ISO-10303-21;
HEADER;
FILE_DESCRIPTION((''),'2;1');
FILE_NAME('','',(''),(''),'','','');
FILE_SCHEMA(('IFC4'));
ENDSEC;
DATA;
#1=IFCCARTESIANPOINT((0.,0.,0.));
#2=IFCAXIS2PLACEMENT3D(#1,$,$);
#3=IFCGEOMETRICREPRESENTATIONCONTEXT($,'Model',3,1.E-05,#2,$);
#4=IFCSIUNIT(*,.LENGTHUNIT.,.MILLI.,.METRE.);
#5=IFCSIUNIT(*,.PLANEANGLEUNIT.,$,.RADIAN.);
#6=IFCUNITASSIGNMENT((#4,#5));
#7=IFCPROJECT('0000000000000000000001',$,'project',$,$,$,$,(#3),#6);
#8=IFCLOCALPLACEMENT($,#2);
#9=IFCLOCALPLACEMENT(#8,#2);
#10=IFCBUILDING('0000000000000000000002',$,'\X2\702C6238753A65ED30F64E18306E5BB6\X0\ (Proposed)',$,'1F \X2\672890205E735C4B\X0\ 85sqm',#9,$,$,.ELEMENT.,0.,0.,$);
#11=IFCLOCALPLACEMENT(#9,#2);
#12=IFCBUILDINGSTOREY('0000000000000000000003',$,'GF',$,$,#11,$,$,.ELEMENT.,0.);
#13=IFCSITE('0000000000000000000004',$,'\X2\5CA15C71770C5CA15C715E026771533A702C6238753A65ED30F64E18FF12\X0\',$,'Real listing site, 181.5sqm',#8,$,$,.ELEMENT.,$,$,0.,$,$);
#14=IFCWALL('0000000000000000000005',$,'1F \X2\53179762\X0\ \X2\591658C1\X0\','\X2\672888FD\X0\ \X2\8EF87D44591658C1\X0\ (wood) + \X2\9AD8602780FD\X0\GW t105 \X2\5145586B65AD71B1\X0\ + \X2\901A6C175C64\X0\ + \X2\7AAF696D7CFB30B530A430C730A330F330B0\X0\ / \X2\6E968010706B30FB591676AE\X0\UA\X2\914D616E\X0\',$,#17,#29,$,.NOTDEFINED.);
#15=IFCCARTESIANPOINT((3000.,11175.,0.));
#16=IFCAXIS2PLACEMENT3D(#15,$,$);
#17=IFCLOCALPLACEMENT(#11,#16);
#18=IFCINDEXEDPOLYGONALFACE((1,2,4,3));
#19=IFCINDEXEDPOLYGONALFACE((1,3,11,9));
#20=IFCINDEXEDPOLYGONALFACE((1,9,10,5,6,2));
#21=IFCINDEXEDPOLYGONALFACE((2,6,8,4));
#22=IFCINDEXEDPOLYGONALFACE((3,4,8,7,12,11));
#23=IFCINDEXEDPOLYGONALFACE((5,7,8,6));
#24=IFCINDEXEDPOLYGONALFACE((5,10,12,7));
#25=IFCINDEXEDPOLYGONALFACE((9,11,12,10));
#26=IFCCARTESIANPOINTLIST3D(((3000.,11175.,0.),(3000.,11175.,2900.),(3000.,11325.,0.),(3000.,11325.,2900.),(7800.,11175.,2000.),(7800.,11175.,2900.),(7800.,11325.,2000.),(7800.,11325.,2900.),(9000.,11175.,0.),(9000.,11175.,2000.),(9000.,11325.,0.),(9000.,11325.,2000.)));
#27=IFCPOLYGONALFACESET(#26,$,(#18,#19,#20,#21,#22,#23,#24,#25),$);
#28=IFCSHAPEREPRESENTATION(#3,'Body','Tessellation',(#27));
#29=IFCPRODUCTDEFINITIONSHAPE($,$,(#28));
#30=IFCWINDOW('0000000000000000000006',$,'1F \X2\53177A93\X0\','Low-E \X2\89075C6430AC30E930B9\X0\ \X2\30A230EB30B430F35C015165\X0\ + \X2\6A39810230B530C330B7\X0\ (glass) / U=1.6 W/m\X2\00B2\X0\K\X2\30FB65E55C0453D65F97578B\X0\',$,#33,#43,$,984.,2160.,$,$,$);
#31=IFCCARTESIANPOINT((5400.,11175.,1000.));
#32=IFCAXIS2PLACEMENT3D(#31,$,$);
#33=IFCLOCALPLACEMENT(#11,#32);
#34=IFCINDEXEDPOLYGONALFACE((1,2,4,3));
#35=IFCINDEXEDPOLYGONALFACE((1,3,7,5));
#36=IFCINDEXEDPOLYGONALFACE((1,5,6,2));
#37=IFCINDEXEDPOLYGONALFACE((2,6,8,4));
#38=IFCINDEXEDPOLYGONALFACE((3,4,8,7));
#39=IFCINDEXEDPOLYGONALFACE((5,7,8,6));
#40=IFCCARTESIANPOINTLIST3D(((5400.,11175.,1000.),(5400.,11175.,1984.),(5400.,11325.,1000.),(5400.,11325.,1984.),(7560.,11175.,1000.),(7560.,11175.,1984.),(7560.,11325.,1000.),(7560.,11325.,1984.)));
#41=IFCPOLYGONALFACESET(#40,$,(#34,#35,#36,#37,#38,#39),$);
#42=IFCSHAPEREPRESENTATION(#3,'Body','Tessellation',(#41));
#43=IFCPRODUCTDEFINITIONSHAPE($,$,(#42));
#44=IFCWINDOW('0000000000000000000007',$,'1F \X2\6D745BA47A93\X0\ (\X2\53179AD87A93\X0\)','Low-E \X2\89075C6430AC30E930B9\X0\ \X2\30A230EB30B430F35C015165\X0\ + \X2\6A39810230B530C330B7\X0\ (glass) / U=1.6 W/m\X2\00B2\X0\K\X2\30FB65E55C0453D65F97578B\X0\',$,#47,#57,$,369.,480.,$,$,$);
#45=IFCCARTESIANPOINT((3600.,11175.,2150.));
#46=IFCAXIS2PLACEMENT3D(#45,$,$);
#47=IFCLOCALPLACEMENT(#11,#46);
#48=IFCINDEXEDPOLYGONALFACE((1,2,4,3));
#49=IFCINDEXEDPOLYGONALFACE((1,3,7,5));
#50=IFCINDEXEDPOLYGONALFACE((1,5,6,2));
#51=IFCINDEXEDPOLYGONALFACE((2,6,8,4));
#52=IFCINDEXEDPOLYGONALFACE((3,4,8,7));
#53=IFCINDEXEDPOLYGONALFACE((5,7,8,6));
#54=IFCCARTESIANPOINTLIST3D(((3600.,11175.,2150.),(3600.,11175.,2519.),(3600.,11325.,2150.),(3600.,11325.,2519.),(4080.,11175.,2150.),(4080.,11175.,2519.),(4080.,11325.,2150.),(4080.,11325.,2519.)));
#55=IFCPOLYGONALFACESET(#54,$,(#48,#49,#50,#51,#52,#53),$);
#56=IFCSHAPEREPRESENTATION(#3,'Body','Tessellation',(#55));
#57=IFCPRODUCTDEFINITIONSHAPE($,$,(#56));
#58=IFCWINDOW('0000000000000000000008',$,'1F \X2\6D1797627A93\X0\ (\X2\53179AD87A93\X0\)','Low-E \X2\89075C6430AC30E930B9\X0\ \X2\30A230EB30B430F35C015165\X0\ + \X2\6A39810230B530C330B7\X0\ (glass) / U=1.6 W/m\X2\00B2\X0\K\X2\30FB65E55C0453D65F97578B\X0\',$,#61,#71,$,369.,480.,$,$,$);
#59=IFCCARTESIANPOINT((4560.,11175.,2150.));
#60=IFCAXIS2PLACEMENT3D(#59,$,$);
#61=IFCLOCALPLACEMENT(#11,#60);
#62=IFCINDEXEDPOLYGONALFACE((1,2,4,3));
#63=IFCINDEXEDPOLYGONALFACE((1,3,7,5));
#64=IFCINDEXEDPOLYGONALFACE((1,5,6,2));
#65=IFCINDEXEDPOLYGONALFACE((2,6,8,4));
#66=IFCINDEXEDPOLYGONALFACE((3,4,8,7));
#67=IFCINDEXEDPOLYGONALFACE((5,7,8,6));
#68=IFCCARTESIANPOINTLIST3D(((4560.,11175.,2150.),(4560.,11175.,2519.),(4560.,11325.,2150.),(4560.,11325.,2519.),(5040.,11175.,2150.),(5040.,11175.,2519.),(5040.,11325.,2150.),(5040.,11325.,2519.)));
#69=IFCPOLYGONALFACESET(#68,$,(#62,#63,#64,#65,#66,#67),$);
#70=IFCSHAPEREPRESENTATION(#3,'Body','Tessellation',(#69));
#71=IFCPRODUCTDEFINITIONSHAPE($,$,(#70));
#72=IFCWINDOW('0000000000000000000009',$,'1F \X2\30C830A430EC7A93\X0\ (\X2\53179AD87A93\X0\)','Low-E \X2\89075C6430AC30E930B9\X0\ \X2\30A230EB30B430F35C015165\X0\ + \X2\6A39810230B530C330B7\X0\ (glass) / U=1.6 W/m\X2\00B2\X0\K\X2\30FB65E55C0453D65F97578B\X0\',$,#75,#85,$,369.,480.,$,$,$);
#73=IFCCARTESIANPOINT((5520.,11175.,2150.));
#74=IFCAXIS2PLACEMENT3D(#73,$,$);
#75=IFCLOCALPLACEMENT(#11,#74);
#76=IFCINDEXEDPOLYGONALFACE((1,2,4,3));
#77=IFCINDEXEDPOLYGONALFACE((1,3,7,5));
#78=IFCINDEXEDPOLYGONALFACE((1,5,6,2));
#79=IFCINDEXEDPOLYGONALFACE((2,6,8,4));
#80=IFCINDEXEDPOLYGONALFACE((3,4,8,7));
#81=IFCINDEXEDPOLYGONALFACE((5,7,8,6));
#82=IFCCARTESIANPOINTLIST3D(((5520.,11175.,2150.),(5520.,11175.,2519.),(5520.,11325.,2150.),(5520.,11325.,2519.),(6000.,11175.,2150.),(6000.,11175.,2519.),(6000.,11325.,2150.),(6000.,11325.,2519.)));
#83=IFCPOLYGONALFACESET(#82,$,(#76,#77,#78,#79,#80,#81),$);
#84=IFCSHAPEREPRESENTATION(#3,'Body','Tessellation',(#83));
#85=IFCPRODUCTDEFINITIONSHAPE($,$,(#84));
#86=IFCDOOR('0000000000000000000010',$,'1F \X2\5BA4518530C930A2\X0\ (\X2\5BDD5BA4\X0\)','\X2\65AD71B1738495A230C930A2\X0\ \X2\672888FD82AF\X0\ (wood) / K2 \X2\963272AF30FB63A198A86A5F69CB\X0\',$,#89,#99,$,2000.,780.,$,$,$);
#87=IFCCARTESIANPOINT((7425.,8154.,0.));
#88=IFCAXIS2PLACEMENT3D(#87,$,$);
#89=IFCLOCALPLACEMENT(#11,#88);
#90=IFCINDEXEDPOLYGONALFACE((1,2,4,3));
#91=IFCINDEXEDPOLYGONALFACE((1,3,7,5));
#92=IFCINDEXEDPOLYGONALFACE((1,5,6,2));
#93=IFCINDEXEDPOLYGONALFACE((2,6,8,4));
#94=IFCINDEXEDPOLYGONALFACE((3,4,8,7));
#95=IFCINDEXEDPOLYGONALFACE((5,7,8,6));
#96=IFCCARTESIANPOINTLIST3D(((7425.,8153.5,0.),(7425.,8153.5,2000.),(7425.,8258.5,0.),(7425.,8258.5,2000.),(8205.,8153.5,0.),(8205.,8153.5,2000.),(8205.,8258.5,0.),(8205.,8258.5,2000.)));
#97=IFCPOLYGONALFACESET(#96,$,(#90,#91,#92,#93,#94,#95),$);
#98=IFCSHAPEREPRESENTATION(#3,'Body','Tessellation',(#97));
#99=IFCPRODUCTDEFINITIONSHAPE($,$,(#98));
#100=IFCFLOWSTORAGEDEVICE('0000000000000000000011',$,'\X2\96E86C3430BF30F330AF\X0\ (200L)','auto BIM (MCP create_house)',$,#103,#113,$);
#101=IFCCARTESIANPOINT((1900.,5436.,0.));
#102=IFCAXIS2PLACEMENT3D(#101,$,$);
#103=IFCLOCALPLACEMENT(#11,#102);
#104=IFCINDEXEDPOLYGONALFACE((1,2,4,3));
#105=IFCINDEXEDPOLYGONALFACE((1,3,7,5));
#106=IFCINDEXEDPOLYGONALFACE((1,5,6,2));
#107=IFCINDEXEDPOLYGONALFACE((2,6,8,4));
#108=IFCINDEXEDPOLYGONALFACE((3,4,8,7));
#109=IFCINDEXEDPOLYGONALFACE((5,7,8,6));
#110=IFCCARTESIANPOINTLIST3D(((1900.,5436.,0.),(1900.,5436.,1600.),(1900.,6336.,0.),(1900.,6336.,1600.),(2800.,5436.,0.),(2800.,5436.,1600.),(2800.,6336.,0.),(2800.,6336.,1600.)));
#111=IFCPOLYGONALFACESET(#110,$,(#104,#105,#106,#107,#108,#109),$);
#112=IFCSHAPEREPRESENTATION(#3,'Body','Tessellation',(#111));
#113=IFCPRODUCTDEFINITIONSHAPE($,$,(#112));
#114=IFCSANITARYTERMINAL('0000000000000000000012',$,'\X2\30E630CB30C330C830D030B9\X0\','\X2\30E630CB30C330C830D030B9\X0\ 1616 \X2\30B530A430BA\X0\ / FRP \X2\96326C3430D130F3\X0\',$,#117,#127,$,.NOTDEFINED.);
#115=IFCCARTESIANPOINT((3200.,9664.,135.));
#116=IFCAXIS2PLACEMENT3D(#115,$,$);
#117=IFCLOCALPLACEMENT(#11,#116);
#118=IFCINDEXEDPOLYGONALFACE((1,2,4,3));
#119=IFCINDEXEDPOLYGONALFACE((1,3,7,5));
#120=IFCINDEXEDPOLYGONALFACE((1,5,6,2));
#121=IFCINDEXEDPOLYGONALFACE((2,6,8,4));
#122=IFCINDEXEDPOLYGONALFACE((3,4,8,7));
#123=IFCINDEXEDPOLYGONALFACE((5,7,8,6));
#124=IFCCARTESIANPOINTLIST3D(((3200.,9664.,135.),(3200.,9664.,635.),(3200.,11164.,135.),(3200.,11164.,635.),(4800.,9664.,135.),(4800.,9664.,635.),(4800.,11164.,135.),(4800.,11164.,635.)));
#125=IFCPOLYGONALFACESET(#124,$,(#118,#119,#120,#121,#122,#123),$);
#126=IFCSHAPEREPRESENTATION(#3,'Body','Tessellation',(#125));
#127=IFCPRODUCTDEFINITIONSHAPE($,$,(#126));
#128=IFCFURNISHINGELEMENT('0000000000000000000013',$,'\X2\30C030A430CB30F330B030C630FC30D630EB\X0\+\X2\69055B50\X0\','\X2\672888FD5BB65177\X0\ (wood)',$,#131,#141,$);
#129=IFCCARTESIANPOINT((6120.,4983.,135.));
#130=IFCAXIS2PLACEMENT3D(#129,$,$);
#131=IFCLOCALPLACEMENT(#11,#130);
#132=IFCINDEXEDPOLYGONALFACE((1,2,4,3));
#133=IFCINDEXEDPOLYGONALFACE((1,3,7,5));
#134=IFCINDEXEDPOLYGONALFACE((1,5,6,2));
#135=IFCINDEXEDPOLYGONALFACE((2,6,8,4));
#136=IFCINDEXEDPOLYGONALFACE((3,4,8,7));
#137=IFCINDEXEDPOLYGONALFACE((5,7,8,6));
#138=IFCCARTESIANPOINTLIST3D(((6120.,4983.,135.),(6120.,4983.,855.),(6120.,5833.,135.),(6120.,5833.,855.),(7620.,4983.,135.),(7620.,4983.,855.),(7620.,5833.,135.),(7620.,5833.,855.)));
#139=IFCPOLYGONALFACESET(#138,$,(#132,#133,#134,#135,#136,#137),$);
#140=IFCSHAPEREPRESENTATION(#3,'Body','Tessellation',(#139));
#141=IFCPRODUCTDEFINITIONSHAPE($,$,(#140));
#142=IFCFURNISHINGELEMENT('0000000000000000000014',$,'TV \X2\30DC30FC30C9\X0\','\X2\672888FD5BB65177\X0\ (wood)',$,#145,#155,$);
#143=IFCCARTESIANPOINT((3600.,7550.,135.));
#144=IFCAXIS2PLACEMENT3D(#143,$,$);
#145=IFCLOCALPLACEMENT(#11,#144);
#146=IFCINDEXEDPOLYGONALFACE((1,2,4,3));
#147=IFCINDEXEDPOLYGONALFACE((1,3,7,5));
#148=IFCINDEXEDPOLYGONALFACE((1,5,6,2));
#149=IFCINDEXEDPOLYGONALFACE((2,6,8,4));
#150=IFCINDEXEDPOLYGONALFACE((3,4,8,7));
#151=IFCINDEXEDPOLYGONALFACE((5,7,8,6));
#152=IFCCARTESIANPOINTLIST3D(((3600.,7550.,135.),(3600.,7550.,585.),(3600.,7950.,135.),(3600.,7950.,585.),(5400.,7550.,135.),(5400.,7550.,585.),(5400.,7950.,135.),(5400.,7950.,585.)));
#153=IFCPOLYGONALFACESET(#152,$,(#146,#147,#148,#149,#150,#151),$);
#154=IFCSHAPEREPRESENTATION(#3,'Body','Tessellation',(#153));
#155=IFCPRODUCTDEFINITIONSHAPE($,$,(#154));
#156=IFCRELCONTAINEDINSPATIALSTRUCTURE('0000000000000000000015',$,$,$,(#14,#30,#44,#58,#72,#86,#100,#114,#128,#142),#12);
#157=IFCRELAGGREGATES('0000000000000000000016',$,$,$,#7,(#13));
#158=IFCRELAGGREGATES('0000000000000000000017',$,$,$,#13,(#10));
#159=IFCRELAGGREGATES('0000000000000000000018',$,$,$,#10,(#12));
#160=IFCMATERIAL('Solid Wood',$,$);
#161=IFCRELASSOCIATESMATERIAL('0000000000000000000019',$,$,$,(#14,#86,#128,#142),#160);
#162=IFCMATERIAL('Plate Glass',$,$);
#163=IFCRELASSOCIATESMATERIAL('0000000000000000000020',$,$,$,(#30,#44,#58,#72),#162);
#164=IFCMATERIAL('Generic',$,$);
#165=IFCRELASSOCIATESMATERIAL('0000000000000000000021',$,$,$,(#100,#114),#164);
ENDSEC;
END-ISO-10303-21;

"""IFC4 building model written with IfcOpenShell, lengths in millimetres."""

from ifc_helpers import new_model, si_unit, frame, frame_2d, origin, place, context, project, spatial, rectangle, extrude, material, element, fill, save


model = new_model("IFC4")

# Units and contexts
model_context = context("Model", 3, precision=1e-05, world=origin())
ifc_project = project(units=[si_unit("LENGTHUNIT", "METRE", prefix="MILLI"), si_unit("PLANEANGLEUNIT", "RADIAN")], contexts=[model_context])

# Site, building, storey
site_placement = place(None, origin())
site = spatial("IfcSite", under=ifc_project, at=site_placement, Name="岡山県岡山市東区瀬戸町旭ヶ丘２", ObjectType="Real listing site, 181.5sqm", CompositionType="ELEMENT", RefElevation=0.0)
building_placement = place(site_placement, origin())
building = spatial("IfcBuilding", under=site, at=building_placement, Name="瀬戸町旭ヶ丘の家 (Proposed)", ObjectType="1F 木造平屋 85sqm", CompositionType="ELEMENT", ElevationOfRefHeight=0.0, ElevationOfTerrain=0.0)
storey_placement = place(building_placement, origin())
storey = spatial("IfcBuildingStorey", under=building, at=storey_placement, Name="GF", CompositionType="ELEMENT", Elevation=0.0)

# Wall, openings, windows
ifc_material_1 = material(Name="Solid Wood")
wall_1_placement = place(storey_placement, frame((3000.0, 11175.0, 0.0)))
wall_1 = element("IfcWall", 1, at=wall_1_placement, inside=storey, material=ifc_material_1, Name="1F 北面 外壁", Description="木製 軸組外壁 (wood) + 高性能GW t105 充填断熱 + 通気層 + 窯業系サイディング / 準耐火・外皮UA配慮", PredefinedType="NOTDEFINED", context=model_context, shape_type="SweptSolid", body=[
    extrude(rectangle(XDim=6000.0, YDim=150.0, at=frame_2d((3000.0, 75.0))), frame((3000.0, 11175.0, 0.0)), (0.0, 0.0, 1.0), 2900.0),
])
opening_1_placement = place(storey_placement, frame((5400.0, 11175.0, 1000.0)))
opening_1 = element("IfcOpeningElement", 2, at=opening_1_placement, cuts=wall_1, PredefinedType="NOTDEFINED", context=model_context, shape_type="SweptSolid", body=[
    extrude(rectangle(XDim=2160.0, YDim=150.0, at=frame_2d((1080.0, 75.0))), frame((5400.0, 11175.0, 1000.0)), (0.0, 0.0, 1.0), 984.0),
])
opening_2_placement = place(storey_placement, frame((3600.0, 11175.0, 2150.0)))
opening_2 = element("IfcOpeningElement", 3, at=opening_2_placement, cuts=wall_1, PredefinedType="NOTDEFINED", context=model_context, shape_type="SweptSolid", body=[
    extrude(rectangle(XDim=480.0, YDim=150.0, at=frame_2d((240.0, 75.0))), frame((3600.0, 11175.0, 2150.0)), (0.0, 0.0, 1.0), 369.0),
])
opening_3_placement = place(storey_placement, frame((4560.0, 11175.0, 2150.0)))
opening_3 = element("IfcOpeningElement", 4, at=opening_3_placement, cuts=wall_1, PredefinedType="NOTDEFINED", context=model_context, shape_type="SweptSolid", body=[
    extrude(rectangle(XDim=480.0, YDim=150.0, at=frame_2d((240.0, 75.0))), frame((4560.0, 11175.0, 2150.0)), (0.0, 0.0, 1.0), 369.0),
])
opening_4_placement = place(storey_placement, frame((5520.0, 11175.0, 2150.0)))
opening_4 = element("IfcOpeningElement", 5, at=opening_4_placement, cuts=wall_1, PredefinedType="NOTDEFINED", context=model_context, shape_type="SweptSolid", body=[
    extrude(rectangle(XDim=480.0, YDim=150.0, at=frame_2d((240.0, 75.0))), frame((5520.0, 11175.0, 2150.0)), (0.0, 0.0, 1.0), 369.0),
])
ifc_material_2 = material(Name="Plate Glass")
window_1_placement = place(storey_placement, frame((5400.0, 11175.0, 1000.0)))
window_1 = element("IfcWindow", 6, at=window_1_placement, inside=storey, material=ifc_material_2, Name="1F 北窓", Description="Low-E 複層ガラス アルゴン封入 + 樹脂サッシ (glass) / U=1.6 W/m²K・日射取得型", OverallHeight=984.0, OverallWidth=2160.0, context=model_context, shape_type="SweptSolid", body=[
    extrude(rectangle(XDim=2160.0, YDim=150.0, at=frame_2d((1080.0, 75.0))), frame((5400.0, 11175.0, 1000.0)), (0.0, 0.0, 1.0), 984.0),
])
fill(opening_1, window_1)
window_2_placement = place(storey_placement, frame((3600.0, 11175.0, 2150.0)))
window_2 = element("IfcWindow", 7, at=window_2_placement, inside=storey, material=ifc_material_2, Name="1F 浴室窓 (北高窓)", Description="Low-E 複層ガラス アルゴン封入 + 樹脂サッシ (glass) / U=1.6 W/m²K・日射取得型", OverallHeight=369.0, OverallWidth=480.0, context=model_context, shape_type="SweptSolid", body=[
    extrude(rectangle(XDim=480.0, YDim=150.0, at=frame_2d((240.0, 75.0))), frame((3600.0, 11175.0, 2150.0)), (0.0, 0.0, 1.0), 369.0),
])
fill(opening_2, window_2)
window_3_placement = place(storey_placement, frame((4560.0, 11175.0, 2150.0)))
window_3 = element("IfcWindow", 8, at=window_3_placement, inside=storey, material=ifc_material_2, Name="1F 洗面窓 (北高窓)", Description="Low-E 複層ガラス アルゴン封入 + 樹脂サッシ (glass) / U=1.6 W/m²K・日射取得型", OverallHeight=369.0, OverallWidth=480.0, context=model_context, shape_type="SweptSolid", body=[
    extrude(rectangle(XDim=480.0, YDim=150.0, at=frame_2d((240.0, 75.0))), frame((4560.0, 11175.0, 2150.0)), (0.0, 0.0, 1.0), 369.0),
])
fill(opening_3, window_3)
window_4_placement = place(storey_placement, frame((5520.0, 11175.0, 2150.0)))
window_4 = element("IfcWindow", 9, at=window_4_placement, inside=storey, material=ifc_material_2, Name="1F トイレ窓 (北高窓)", Description="Low-E 複層ガラス アルゴン封入 + 樹脂サッシ (glass) / U=1.6 W/m²K・日射取得型", OverallHeight=369.0, OverallWidth=480.0, context=model_context, shape_type="SweptSolid", body=[
    extrude(rectangle(XDim=480.0, YDim=150.0, at=frame_2d((240.0, 75.0))), frame((5520.0, 11175.0, 2150.0)), (0.0, 0.0, 1.0), 369.0),
])
fill(opening_4, window_4)

# Door
door_1_placement = place(storey_placement, frame((7425.0, 8154.0, 0.0)))
element("IfcDoor", 10, at=door_1_placement, inside=storey, material=ifc_material_1, Name="1F 室内ドア (寝室)", Description="断熱玄関ドア 木製芯 (wood) / K2 防犯・採風機構", OverallHeight=2000.0, OverallWidth=780.0, context=model_context, shape_type="SweptSolid", body=[
    extrude(rectangle(XDim=780.0, YDim=105.0, at=frame_2d((390.0, 52.0))), frame((7425.0, 8154.0, 0.0)), (0.0, 0.0, 1.0), 2000.0),
])

# Flow storage device
ifc_material_3 = material(Name="Generic")
flow_storage_device_placement = place(storey_placement, frame((1900.0, 5436.0, 0.0)))
element("IfcFlowStorageDevice", 11, at=flow_storage_device_placement, inside=storey, material=ifc_material_3, Name="雨水タンク (200L)", Description="auto BIM (MCP create_house)", context=model_context, shape_type="SweptSolid", body=[
    extrude(rectangle(XDim=900.0, YDim=900.0, at=frame_2d((450.0, 450.0))), frame((1900.0, 5436.0, 0.0)), (0.0, 0.0, 1.0), 1600.0),
])

# Sanitary terminal
sanitary_terminal_placement = place(storey_placement, frame((3200.0, 9664.0, 135.0)))
element("IfcSanitaryTerminal", 12, at=sanitary_terminal_placement, inside=storey, material=ifc_material_3, Name="ユニットバス", Description="ユニットバス 1616 サイズ / FRP 防水パン", PredefinedType="NOTDEFINED", context=model_context, shape_type="SweptSolid", body=[
    extrude(rectangle(XDim=1600.0, YDim=1500.0, at=frame_2d((800.0, 750.0))), frame((3200.0, 9664.0, 135.0)), (0.0, 0.0, 1.0), 500.0),
])

# Furnishing elements
furnishing_1_placement = place(storey_placement, frame((6120.0, 4983.0, 135.0)))
element("IfcFurnishingElement", 13, at=furnishing_1_placement, inside=storey, material=ifc_material_1, Name="ダイニングテーブル+椅子", Description="木製家具 (wood)", context=model_context, shape_type="SweptSolid", body=[
    extrude(rectangle(XDim=1500.0, YDim=850.0, at=frame_2d((750.0, 425.0))), frame((6120.0, 4983.0, 135.0)), (0.0, 0.0, 1.0), 720.0),
])
furnishing_2_placement = place(storey_placement, frame((3600.0, 7550.0, 135.0)))
element("IfcFurnishingElement", 14, at=furnishing_2_placement, inside=storey, material=ifc_material_1, Name="TV ボード", Description="木製家具 (wood)", context=model_context, shape_type="SweptSolid", body=[
    extrude(rectangle(XDim=1800.0, YDim=400.0, at=frame_2d((900.0, 200.0))), frame((3600.0, 7550.0, 135.0)), (0.0, 0.0, 1.0), 450.0),
])

save(model, "model.ifc")
